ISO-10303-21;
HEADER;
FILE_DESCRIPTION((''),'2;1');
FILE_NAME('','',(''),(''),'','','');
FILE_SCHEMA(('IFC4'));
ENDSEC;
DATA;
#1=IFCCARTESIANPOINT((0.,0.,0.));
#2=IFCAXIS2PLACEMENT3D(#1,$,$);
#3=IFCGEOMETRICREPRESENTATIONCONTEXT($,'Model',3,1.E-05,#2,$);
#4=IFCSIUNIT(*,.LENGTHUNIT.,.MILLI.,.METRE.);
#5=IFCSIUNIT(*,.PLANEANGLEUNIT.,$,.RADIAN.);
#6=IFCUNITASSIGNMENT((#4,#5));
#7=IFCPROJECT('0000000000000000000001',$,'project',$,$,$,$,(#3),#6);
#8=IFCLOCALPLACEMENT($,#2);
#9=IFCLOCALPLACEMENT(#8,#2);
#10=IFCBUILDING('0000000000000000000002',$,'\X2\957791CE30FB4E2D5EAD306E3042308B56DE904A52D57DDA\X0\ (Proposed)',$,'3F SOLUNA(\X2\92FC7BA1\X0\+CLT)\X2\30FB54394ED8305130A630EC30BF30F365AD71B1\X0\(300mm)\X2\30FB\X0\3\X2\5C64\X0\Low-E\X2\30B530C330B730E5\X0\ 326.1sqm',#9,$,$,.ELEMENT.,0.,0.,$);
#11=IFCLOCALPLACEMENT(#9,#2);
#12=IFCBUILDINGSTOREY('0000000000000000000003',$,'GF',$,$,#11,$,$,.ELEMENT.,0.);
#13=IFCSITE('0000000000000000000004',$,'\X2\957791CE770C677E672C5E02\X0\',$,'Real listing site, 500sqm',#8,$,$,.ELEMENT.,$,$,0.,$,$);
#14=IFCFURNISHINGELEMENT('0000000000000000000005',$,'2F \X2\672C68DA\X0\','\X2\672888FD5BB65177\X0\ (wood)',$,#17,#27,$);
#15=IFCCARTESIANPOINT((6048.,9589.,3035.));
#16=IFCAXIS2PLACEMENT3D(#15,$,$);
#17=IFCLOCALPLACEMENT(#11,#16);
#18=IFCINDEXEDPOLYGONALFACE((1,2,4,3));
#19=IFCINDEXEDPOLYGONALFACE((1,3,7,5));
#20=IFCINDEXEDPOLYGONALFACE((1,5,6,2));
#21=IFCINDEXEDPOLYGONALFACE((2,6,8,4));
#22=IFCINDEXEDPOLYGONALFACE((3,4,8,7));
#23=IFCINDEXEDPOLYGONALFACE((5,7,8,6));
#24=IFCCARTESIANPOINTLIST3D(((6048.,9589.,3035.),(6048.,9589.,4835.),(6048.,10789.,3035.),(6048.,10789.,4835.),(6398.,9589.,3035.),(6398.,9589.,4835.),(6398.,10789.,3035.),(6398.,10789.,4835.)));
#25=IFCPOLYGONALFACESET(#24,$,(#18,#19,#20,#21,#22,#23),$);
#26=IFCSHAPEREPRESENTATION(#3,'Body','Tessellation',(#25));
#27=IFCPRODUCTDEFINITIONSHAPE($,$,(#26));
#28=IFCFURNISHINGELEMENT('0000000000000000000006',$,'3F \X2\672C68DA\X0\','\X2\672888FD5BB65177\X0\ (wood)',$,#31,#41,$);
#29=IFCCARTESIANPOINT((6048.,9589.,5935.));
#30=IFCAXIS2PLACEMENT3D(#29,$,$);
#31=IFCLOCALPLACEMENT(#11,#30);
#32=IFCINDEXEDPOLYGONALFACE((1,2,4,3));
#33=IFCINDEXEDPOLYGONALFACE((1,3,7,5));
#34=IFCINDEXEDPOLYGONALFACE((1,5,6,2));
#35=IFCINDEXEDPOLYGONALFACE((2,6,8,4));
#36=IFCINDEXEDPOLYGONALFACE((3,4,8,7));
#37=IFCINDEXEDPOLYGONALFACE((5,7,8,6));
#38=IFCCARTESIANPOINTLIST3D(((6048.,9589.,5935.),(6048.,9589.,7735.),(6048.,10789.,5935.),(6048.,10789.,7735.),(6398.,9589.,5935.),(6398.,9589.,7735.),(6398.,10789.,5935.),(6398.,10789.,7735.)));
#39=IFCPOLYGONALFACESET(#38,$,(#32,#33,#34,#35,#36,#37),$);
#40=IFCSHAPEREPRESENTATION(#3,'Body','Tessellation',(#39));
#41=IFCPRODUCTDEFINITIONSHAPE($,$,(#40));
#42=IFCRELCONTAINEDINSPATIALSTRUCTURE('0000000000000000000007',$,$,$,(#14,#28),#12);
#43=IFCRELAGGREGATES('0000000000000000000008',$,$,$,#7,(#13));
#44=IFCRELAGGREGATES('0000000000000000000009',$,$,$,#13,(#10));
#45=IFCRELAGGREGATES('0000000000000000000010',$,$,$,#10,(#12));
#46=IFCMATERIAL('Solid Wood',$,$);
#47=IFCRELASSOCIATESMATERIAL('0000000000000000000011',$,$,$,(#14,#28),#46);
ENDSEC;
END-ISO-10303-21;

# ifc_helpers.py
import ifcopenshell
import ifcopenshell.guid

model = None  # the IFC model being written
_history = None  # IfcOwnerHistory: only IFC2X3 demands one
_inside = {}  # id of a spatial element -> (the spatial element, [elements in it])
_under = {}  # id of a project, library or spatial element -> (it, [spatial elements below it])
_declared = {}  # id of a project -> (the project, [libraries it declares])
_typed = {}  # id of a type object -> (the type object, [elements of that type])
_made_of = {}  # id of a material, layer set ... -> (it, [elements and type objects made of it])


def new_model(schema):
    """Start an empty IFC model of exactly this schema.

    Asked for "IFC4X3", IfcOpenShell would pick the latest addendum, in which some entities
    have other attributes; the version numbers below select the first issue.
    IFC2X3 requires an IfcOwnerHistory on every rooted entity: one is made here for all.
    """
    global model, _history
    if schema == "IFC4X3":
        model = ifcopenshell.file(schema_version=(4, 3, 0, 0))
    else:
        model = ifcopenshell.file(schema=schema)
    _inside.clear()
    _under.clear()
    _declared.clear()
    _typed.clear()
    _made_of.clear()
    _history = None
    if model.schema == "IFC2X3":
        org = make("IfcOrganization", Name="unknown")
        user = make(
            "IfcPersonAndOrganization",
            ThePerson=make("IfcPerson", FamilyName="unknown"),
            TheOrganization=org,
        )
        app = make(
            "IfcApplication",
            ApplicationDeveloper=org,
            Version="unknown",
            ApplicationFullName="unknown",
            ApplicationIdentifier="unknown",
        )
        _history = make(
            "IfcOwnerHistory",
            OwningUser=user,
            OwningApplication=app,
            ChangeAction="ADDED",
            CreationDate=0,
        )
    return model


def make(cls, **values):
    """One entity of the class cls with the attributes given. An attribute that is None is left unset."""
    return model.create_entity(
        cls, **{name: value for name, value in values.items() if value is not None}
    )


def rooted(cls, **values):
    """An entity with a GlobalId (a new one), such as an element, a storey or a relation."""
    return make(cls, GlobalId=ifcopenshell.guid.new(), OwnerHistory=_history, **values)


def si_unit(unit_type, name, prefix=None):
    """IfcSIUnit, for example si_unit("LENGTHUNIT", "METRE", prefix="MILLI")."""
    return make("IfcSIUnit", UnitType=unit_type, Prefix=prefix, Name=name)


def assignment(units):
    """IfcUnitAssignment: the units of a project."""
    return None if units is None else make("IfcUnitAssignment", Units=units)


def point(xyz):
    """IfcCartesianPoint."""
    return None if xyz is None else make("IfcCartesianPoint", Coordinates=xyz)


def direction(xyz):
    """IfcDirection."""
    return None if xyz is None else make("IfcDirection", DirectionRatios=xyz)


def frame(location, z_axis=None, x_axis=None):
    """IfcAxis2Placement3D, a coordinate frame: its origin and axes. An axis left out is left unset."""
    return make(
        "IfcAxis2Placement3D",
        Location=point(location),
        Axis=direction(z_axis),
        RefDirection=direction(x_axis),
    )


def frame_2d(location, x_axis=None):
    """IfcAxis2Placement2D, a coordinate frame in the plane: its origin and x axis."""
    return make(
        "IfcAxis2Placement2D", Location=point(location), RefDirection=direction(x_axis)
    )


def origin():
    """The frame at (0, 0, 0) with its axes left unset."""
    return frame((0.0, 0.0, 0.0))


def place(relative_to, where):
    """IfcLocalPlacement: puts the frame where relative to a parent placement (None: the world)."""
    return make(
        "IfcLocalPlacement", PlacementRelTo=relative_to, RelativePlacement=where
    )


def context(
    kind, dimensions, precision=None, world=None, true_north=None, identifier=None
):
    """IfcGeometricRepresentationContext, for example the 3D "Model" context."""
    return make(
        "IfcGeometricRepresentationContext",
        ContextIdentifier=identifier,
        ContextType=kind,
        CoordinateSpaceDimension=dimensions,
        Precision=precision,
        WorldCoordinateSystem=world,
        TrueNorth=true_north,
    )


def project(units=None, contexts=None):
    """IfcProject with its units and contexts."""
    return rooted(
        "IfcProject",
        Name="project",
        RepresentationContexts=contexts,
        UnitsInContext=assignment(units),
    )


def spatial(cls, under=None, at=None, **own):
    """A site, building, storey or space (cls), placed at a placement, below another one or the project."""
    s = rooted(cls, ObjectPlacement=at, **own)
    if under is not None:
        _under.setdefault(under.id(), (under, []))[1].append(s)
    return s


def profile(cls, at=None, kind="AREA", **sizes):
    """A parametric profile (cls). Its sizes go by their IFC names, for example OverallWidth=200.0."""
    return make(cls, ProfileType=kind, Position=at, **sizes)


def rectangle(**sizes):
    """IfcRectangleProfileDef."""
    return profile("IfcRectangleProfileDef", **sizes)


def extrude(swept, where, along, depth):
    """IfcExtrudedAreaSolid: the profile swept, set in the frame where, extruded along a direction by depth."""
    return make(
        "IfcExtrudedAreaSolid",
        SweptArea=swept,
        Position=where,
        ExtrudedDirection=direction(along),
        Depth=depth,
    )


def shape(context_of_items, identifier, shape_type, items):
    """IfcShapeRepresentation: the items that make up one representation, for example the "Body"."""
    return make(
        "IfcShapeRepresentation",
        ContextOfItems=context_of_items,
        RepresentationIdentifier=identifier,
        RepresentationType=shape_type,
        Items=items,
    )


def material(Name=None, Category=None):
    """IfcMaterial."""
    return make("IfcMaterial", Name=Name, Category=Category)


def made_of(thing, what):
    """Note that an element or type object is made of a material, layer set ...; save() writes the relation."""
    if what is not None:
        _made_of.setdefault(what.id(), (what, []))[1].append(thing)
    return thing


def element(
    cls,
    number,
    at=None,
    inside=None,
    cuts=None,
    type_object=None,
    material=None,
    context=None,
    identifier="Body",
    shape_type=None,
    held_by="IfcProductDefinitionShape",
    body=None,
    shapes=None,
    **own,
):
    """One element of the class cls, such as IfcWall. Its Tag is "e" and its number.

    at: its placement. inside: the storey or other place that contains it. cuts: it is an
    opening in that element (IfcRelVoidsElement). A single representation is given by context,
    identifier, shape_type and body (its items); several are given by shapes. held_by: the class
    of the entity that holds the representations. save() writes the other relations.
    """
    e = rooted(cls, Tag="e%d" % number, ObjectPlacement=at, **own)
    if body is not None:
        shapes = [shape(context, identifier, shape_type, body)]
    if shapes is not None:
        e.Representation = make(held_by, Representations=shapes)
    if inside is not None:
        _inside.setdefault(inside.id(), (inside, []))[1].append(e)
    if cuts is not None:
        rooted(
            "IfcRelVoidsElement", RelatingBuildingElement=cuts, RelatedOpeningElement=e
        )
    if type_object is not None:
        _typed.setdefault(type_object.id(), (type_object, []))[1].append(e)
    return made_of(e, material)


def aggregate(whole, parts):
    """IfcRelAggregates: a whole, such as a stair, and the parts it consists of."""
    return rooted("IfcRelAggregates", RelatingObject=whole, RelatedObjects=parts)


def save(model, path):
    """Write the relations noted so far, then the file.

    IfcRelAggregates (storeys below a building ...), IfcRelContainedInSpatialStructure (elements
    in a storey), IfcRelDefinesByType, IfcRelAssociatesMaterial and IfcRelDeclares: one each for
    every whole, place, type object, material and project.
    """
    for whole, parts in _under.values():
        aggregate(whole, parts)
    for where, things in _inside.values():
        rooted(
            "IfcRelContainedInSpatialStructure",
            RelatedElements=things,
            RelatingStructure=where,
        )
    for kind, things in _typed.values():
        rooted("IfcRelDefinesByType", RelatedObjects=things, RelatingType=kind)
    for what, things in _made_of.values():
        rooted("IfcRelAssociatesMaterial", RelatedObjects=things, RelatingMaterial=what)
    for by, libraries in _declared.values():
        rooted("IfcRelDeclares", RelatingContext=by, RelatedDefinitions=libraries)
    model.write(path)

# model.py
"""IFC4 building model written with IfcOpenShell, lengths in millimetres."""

from ifc_helpers import new_model, si_unit, frame, frame_2d, origin, place, context, project, spatial, rectangle, extrude, material, element, save


model = new_model("IFC4")

# Units and contexts
model_context = context("Model", 3, precision=1e-05, world=origin())
ifc_project = project(units=[si_unit("LENGTHUNIT", "METRE", prefix="MILLI"), si_unit("PLANEANGLEUNIT", "RADIAN")], contexts=[model_context])

# Site, building, storey
site_placement = place(None, origin())
site = spatial("IfcSite", under=ifc_project, at=site_placement, Name="長野県松本市", ObjectType="Real listing site, 500sqm", CompositionType="ELEMENT", RefElevation=0.0)
building_placement = place(site_placement, origin())
building = spatial("IfcBuilding", under=site, at=building_placement, Name="長野・中庭のある回遊動線 (Proposed)", ObjectType="3F SOLUNA(鋼管+CLT)・吹付けウレタン断熱(300mm)・3層Low-Eサッシュ 326.1sqm", CompositionType="ELEMENT", ElevationOfRefHeight=0.0, ElevationOfTerrain=0.0)
storey_placement = place(building_placement, origin())
storey = spatial("IfcBuildingStorey", under=building, at=storey_placement, Name="GF", CompositionType="ELEMENT", Elevation=0.0)

# Shared definitions
ifc_material_1 = material(Name="Solid Wood")

# Furnishing elements
furnishing_1_placement = place(storey_placement, frame((6048.0, 9589.0, 3035.0)))
element("IfcFurnishingElement", 1, at=furnishing_1_placement, inside=storey, material=ifc_material_1, Name="2F 本棚", Description="木製家具 (wood)", context=model_context, shape_type="SweptSolid", body=[
    extrude(rectangle(XDim=350.0, YDim=1200.0, at=frame_2d((175.0, 600.0))), frame((6048.0, 9589.0, 3035.0)), (0.0, 0.0, 1.0), 1800.0),
])
furnishing_2_placement = place(storey_placement, frame((6048.0, 9589.0, 5935.0)))
element("IfcFurnishingElement", 2, at=furnishing_2_placement, inside=storey, material=ifc_material_1, Name="3F 本棚", Description="木製家具 (wood)", context=model_context, shape_type="SweptSolid", body=[
    extrude(rectangle(XDim=350.0, YDim=1200.0, at=frame_2d((175.0, 600.0))), frame((6048.0, 9589.0, 5935.0)), (0.0, 0.0, 1.0), 1800.0),
])

save(model, "model.ifc")
